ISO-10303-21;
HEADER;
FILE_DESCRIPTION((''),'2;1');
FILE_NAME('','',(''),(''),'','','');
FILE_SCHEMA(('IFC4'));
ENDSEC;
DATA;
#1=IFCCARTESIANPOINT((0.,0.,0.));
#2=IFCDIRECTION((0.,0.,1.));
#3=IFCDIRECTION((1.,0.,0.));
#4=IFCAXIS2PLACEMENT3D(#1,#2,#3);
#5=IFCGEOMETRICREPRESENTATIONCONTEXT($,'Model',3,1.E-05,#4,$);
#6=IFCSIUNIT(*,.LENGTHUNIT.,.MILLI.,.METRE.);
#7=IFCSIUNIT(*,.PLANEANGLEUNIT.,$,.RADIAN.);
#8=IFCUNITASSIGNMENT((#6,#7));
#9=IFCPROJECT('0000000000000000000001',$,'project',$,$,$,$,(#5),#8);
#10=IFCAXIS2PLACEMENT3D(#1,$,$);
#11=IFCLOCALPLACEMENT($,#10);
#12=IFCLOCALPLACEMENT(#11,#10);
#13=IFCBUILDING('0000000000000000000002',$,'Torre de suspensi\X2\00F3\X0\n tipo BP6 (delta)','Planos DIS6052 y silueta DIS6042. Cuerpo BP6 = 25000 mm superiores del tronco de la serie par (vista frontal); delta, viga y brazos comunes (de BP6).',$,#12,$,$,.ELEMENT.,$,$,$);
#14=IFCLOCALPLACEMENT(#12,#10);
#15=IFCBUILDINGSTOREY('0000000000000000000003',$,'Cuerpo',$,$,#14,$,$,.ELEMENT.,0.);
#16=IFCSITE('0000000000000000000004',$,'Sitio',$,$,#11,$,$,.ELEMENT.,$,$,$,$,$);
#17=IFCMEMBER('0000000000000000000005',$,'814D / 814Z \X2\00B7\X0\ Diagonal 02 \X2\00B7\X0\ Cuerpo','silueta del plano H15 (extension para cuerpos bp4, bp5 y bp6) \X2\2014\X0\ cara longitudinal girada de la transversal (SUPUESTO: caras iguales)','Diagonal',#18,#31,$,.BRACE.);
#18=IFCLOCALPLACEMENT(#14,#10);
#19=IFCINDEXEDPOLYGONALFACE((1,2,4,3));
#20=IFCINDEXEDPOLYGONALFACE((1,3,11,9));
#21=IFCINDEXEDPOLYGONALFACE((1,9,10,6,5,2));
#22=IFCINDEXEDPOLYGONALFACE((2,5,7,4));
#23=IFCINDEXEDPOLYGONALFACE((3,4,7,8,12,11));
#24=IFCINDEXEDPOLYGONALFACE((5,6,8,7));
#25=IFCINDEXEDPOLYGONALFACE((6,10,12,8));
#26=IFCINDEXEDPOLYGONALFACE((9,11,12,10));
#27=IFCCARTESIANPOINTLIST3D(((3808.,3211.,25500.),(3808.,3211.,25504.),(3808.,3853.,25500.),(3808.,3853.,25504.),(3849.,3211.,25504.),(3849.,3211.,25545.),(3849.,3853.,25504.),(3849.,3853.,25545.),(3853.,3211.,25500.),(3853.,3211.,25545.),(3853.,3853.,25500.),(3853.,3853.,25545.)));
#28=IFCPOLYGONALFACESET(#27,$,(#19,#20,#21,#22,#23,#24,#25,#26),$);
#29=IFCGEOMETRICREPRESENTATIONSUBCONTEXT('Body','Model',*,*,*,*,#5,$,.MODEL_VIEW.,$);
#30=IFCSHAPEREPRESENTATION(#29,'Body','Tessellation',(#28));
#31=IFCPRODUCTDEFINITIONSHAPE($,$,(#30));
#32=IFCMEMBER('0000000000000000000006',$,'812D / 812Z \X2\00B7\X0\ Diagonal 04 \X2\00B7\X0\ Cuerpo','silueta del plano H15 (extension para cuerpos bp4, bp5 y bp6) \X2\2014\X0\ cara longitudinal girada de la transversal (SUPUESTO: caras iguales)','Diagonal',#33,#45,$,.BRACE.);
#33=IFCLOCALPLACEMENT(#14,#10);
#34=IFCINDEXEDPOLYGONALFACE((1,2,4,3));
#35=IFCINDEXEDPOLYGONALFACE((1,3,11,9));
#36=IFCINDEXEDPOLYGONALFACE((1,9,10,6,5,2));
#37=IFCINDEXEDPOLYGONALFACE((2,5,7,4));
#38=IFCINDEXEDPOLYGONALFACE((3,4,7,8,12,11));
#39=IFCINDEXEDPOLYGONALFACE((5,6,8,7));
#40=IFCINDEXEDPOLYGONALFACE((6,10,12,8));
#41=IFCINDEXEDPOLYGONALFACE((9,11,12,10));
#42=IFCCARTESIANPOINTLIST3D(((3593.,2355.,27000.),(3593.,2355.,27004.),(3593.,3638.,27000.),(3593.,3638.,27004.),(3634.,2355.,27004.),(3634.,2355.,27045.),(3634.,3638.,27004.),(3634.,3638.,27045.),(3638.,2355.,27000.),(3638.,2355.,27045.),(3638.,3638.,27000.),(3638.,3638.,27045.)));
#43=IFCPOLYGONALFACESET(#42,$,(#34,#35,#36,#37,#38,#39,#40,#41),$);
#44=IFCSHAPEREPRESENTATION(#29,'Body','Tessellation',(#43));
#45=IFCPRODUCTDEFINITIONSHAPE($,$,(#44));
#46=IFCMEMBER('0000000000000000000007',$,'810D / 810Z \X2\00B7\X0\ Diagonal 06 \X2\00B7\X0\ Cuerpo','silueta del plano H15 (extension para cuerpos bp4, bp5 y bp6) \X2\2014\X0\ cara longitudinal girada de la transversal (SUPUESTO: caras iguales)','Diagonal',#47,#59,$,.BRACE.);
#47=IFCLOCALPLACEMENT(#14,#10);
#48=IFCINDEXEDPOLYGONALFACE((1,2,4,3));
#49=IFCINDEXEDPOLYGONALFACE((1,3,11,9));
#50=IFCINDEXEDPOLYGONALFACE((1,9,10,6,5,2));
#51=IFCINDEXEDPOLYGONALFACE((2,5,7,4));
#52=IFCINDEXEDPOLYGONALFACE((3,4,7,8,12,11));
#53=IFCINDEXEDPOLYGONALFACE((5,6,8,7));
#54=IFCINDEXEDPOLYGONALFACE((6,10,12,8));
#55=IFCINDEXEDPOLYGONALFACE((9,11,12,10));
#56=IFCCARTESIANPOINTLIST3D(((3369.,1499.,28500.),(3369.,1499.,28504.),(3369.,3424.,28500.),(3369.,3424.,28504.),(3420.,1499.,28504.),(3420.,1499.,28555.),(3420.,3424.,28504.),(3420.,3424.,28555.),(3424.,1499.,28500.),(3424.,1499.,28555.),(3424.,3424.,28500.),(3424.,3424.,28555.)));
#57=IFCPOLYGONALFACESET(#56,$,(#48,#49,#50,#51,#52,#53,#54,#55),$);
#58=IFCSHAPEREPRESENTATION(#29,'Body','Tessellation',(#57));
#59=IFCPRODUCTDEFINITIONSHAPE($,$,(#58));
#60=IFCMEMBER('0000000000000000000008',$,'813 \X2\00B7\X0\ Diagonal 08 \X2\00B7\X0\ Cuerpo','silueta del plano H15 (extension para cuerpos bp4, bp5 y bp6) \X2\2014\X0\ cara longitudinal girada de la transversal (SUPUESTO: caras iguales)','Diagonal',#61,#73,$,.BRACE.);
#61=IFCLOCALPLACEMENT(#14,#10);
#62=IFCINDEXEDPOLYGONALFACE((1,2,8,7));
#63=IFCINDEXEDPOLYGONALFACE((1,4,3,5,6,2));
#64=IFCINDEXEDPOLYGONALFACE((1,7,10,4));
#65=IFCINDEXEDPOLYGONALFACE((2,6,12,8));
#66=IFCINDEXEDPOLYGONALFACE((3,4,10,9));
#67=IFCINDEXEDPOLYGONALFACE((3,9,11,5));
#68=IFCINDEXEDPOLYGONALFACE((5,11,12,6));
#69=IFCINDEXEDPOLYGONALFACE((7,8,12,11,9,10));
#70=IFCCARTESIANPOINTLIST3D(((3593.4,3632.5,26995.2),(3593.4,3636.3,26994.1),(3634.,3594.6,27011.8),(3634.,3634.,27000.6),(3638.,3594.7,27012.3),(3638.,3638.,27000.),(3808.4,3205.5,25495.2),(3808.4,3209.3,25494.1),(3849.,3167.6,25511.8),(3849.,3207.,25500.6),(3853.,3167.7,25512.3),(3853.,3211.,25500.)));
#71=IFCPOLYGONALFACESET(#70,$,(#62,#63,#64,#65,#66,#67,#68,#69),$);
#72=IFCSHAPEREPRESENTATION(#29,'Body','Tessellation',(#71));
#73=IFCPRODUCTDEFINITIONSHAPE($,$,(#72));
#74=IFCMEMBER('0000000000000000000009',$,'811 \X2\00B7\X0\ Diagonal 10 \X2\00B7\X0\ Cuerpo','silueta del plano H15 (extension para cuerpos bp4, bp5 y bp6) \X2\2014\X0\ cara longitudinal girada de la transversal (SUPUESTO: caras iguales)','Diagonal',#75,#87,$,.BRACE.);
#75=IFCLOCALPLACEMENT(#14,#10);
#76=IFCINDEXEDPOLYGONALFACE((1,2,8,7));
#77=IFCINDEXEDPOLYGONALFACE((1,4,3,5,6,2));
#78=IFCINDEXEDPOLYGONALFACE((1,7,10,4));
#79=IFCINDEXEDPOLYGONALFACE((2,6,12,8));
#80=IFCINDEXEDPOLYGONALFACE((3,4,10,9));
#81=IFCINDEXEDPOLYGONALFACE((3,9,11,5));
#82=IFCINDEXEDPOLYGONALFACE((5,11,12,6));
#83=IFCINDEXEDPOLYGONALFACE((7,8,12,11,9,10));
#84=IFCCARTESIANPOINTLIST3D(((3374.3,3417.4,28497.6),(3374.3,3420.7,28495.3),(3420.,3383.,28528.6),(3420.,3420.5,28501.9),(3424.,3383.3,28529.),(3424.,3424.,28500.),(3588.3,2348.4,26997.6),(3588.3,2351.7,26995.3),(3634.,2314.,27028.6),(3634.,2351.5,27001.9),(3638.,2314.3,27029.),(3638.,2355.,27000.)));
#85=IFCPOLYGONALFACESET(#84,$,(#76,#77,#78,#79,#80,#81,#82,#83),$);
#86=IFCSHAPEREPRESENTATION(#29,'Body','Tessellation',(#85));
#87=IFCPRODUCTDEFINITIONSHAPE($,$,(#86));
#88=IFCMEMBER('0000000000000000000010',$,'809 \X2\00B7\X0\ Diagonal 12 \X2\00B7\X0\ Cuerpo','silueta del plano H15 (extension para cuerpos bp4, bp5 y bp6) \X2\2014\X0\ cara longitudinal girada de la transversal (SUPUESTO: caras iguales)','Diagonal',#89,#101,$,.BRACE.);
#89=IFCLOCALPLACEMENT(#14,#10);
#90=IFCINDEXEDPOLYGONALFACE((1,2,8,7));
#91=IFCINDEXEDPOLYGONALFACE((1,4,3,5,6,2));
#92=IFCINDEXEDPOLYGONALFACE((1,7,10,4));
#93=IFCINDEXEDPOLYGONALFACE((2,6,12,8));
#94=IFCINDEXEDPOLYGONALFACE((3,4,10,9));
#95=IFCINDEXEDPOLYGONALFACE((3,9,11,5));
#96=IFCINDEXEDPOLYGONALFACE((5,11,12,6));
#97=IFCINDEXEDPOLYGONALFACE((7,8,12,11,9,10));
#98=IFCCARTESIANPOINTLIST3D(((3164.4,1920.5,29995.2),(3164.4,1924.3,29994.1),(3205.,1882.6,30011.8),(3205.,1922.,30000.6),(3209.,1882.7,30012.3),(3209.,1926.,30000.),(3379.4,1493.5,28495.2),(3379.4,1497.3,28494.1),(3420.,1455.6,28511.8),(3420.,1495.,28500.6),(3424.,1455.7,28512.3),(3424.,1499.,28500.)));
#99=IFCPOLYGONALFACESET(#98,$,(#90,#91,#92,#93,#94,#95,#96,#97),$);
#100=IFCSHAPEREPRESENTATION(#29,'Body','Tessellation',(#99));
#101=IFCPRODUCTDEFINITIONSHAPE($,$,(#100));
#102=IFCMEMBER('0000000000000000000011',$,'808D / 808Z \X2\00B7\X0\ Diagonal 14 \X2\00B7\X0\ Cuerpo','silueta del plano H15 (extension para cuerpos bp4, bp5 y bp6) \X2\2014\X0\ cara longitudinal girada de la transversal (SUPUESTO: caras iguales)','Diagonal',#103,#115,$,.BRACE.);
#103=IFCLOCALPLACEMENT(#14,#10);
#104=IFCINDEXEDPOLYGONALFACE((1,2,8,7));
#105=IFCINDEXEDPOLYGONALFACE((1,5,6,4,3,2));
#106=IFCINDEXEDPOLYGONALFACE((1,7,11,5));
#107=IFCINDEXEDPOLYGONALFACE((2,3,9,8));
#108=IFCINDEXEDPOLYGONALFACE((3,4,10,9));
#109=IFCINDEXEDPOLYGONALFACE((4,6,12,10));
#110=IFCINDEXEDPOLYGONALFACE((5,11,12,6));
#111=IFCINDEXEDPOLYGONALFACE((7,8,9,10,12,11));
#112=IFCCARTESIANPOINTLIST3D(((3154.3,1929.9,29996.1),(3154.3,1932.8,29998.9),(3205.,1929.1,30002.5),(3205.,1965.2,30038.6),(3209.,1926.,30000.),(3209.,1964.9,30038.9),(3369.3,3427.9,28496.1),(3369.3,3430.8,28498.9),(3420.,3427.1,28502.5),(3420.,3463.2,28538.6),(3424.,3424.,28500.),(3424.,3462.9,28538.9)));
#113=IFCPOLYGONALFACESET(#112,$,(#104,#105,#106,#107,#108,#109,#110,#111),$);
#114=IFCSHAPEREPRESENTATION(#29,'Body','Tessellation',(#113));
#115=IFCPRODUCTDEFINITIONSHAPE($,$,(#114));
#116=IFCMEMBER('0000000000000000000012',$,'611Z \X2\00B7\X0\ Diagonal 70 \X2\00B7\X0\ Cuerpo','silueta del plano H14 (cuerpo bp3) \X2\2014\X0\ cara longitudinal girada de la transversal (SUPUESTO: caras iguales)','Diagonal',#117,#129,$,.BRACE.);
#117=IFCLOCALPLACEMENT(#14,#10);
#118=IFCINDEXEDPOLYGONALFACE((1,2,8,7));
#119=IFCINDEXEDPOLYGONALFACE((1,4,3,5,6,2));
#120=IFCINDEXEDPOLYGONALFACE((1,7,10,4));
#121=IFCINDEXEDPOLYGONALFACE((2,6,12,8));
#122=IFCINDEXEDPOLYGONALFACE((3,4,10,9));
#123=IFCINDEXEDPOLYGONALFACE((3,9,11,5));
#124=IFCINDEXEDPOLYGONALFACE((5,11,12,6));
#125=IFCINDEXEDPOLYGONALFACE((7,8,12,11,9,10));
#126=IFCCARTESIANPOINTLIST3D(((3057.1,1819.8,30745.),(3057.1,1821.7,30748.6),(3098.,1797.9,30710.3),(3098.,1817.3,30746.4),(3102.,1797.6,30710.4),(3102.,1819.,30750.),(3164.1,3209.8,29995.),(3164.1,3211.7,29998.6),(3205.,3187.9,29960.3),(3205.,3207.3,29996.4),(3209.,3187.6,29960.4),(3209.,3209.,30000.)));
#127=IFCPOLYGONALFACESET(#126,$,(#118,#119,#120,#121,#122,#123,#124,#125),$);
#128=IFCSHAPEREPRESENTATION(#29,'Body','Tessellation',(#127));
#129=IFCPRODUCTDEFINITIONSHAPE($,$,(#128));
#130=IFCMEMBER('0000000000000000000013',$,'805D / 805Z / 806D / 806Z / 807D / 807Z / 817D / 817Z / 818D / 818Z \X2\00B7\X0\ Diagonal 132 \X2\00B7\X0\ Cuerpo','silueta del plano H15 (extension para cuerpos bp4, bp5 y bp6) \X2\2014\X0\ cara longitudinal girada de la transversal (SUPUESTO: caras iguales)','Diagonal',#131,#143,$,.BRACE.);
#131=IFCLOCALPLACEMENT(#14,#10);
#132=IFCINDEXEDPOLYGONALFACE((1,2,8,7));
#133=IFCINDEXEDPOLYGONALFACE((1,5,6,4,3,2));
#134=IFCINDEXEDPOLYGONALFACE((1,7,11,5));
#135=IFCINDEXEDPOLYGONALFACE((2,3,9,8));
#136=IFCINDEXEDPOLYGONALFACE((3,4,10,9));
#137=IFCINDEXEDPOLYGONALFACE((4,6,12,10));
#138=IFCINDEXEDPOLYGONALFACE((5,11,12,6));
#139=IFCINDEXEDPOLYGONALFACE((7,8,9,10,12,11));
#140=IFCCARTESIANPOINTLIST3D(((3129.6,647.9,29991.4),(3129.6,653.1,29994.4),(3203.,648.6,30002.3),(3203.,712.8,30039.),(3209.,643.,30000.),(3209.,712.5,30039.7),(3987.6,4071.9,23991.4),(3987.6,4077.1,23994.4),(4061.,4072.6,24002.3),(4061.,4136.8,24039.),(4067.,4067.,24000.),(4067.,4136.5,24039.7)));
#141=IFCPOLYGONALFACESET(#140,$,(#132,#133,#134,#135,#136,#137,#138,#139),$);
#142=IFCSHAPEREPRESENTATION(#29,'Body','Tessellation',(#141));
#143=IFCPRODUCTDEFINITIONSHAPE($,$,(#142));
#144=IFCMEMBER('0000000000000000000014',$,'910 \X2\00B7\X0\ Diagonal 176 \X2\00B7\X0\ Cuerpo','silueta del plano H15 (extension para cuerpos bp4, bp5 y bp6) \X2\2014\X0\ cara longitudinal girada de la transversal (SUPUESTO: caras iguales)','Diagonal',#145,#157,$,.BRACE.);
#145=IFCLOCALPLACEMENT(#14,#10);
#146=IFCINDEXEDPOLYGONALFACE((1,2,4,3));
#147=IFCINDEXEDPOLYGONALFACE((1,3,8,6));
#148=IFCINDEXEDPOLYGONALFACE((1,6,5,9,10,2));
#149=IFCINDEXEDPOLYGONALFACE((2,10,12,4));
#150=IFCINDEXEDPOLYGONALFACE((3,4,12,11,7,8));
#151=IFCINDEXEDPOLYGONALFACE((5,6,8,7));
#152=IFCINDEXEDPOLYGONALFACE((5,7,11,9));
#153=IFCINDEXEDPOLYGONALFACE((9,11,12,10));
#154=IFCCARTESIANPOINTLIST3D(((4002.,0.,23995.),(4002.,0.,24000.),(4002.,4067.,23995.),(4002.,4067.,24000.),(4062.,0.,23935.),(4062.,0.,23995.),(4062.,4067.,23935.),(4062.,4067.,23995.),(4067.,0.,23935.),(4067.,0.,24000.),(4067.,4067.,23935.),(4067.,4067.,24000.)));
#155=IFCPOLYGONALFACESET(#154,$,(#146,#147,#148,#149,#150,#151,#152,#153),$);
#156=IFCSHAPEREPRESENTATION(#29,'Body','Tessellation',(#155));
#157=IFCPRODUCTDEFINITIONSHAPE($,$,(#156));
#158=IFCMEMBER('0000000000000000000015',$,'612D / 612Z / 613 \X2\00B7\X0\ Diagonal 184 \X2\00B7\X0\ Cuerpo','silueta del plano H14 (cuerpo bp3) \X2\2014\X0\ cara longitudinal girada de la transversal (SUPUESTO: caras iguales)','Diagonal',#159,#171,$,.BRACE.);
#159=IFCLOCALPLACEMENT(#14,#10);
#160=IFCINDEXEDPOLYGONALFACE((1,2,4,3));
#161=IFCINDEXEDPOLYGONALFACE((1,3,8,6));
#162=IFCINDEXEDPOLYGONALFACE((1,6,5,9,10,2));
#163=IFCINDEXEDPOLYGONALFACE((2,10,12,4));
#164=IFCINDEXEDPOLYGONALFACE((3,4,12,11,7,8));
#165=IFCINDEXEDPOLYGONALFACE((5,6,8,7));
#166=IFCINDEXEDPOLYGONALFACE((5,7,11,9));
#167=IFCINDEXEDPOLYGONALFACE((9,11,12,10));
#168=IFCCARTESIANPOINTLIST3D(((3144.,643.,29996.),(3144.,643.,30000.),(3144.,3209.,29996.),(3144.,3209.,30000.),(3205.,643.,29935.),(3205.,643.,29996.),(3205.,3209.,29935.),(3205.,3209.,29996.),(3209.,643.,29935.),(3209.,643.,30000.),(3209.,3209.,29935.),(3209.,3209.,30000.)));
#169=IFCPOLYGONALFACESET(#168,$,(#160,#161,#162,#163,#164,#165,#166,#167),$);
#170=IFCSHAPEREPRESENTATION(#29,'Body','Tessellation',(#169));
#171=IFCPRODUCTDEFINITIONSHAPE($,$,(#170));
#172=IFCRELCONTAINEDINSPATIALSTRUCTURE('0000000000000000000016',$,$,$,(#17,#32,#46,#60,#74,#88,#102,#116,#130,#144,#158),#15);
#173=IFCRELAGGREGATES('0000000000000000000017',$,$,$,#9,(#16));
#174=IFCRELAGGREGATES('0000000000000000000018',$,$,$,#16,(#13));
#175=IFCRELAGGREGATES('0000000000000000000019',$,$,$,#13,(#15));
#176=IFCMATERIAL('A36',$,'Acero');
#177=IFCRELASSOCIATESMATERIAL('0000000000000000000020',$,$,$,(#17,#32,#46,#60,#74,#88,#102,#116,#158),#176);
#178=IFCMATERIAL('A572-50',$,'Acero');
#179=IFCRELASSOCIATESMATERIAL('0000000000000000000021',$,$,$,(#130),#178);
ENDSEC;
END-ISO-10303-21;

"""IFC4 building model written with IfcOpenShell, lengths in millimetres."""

from ifc_helpers import new_model, si_unit, frame, frame_2d, origin, origin_with_axes, place, context, subcontext, project, spatial, l_section, extrude, material, element, save


model = new_model("IFC4")

# Units and contexts
model_context = context("Model", 3, precision=1e-05, world=origin_with_axes())
body_context = subcontext(model_context, "Body", "Model", "MODEL_VIEW")
ifc_project = project(units=[si_unit("LENGTHUNIT", "METRE", prefix="MILLI"), si_unit("PLANEANGLEUNIT", "RADIAN")], contexts=[model_context])

# Site, building, storey
site_placement = place(None, origin())
site = spatial("IfcSite", under=ifc_project, at=site_placement, Name="Sitio", CompositionType="ELEMENT")
building_placement = place(site_placement, origin())
building = spatial("IfcBuilding", under=site, at=building_placement, Name="Torre de suspensión tipo BP6 (delta)", Description="Planos DIS6052 y silueta DIS6042. Cuerpo BP6 = 25000 mm superiores del tronco de la serie par (vista frontal); delta, viga y brazos comunes (de BP6).", CompositionType="ELEMENT")
storey_placement = place(building_placement, origin())
storey = spatial("IfcBuildingStorey", under=building, at=storey_placement, Name="Cuerpo", CompositionType="ELEMENT", Elevation=0.0)

# Members
ifc_material_1 = material(Name="A36", Category="Acero")
ifc_material_2 = material(Name="A572-50", Category="Acero")
member_1_placement = place(storey_placement, frame((3853.0, 3211.0, 25500.0), z_axis=(0.0, 1.0, 0.0), x_axis=(-1.0, 0.0, 0.0)))
element("IfcMember", 1, at=member_1_placement, inside=storey, material=ifc_material_1, Name="814D / 814Z · Diagonal 02 · Cuerpo", Description="silueta del plano H15 (extension para cuerpos bp4, bp5 y bp6) — cara longitudinal girada de la transversal (SUPUESTO: caras iguales)", ObjectType="Diagonal", PredefinedType="BRACE", context=body_context, shape_type="SweptSolid", body=[
    extrude(l_section(Depth=45.0, Width=45.0, Thickness=4.0, at=frame_2d((22.5, 22.5))), None, (0.0, 0.0, 1.0), 642.0),
])
member_2_placement = place(storey_placement, frame((3638.0, 2355.0, 27000.0), z_axis=(0.0, 1.0, 0.0), x_axis=(-1.0, 0.0, 0.0)))
element("IfcMember", 2, at=member_2_placement, inside=storey, material=ifc_material_1, Name="812D / 812Z · Diagonal 04 · Cuerpo", Description="silueta del plano H15 (extension para cuerpos bp4, bp5 y bp6) — cara longitudinal girada de la transversal (SUPUESTO: caras iguales)", ObjectType="Diagonal", PredefinedType="BRACE", context=body_context, shape_type="SweptSolid", body=[
    extrude(l_section(Depth=45.0, Width=45.0, Thickness=4.0, at=frame_2d((22.5, 22.5))), None, (0.0, 0.0, 1.0), 1283.0),
])
member_3_placement = place(storey_placement, frame((3424.0, 1499.0, 28500.0), z_axis=(0.0, 1.0, 0.0), x_axis=(-1.0, 0.0, 0.0)))
element("IfcMember", 3, at=member_3_placement, inside=storey, material=ifc_material_1, Name="810D / 810Z · Diagonal 06 · Cuerpo", Description="silueta del plano H15 (extension para cuerpos bp4, bp5 y bp6) — cara longitudinal girada de la transversal (SUPUESTO: caras iguales)", ObjectType="Diagonal", PredefinedType="BRACE", context=body_context, shape_type="SweptSolid", body=[
    extrude(l_section(Depth=55.0, Width=55.0, Thickness=4.0, at=frame_2d((27.5, 27.5))), None, (0.0, 0.0, 1.0), 1925.0),
])
member_4_placement = place(storey_placement, frame((3853.0, 3211.0, 25500.0), z_axis=(-0.136565, 0.271224, 0.952779), x_axis=(-0.990631, -0.03739, -0.131347)))
element("IfcMember", 4, at=member_4_placement, inside=storey, material=ifc_material_1, Name="813 · Diagonal 08 · Cuerpo", Description="silueta del plano H15 (extension para cuerpos bp4, bp5 y bp6) — cara longitudinal girada de la transversal (SUPUESTO: caras iguales)", ObjectType="Diagonal", PredefinedType="BRACE", context=body_context, shape_type="SweptSolid", body=[
    extrude(l_section(Depth=45.0, Width=45.0, Thickness=4.0, at=frame_2d((22.5, 22.5))), None, (0.0, 0.0, 1.0), 1574.3),
])
member_5_placement = place(storey_placement, frame((3638.0, 2355.0, 27000.0), z_axis=(-0.115405, 0.576487, 0.808915), x_axis=(-0.993318, -0.066977, -0.093981)))
element("IfcMember", 5, at=member_5_placement, inside=storey, material=ifc_material_1, Name="811 · Diagonal 10 · Cuerpo", Description="silueta del plano H15 (extension para cuerpos bp4, bp5 y bp6) — cara longitudinal girada de la transversal (SUPUESTO: caras iguales)", ObjectType="Diagonal", PredefinedType="BRACE", context=body_context, shape_type="SweptSolid", body=[
    extrude(l_section(Depth=50.0, Width=50.0, Thickness=4.0, at=frame_2d((25.0, 25.0))), None, (0.0, 0.0, 1.0), 1854.3),
])
member_6_placement = place(storey_placement, frame((3424.0, 1499.0, 28500.0), z_axis=(-0.136565, 0.271224, 0.952779), x_axis=(-0.990631, -0.03739, -0.131347)))
element("IfcMember", 6, at=member_6_placement, inside=storey, material=ifc_material_1, Name="809 · Diagonal 12 · Cuerpo", Description="silueta del plano H15 (extension para cuerpos bp4, bp5 y bp6) — cara longitudinal girada de la transversal (SUPUESTO: caras iguales)", ObjectType="Diagonal", PredefinedType="BRACE", context=body_context, shape_type="SweptSolid", body=[
    extrude(l_section(Depth=45.0, Width=45.0, Thickness=4.0, at=frame_2d((22.5, 22.5))), None, (0.0, 0.0, 1.0), 1574.3),
])
member_7_placement = place(storey_placement, frame((3209.0, 1926.0, 30000.0), z_axis=(0.100902, 0.703029, -0.703967), x_axis=(-0.994896, 0.071301, -0.071396)))
element("IfcMember", 7, at=member_7_placement, inside=storey, material=ifc_material_1, Name="808D / 808Z · Diagonal 14 · Cuerpo", Description="silueta del plano H15 (extension para cuerpos bp4, bp5 y bp6) — cara longitudinal girada de la transversal (SUPUESTO: caras iguales)", ObjectType="Diagonal", PredefinedType="BRACE", context=body_context, shape_type="SweptSolid", body=[
    extrude(l_section(Depth=55.0, Width=55.0, Thickness=4.0, at=frame_2d((27.5, 27.5))), None, (0.0, 0.0, 1.0), 2130.8),
])
member_8_placement = place(storey_placement, frame((3209.0, 3209.0, 30000.0), z_axis=(-0.067591, -0.878052, 0.473769), x_axis=(-0.997713, 0.059484, -0.032096)))
element("IfcMember", 8, at=member_8_placement, inside=storey, material=ifc_material_1, Name="611Z · Diagonal 70 · Cuerpo", Description="silueta del plano H14 (cuerpo bp3) — cara longitudinal girada de la transversal (SUPUESTO: caras iguales)", ObjectType="Diagonal", PredefinedType="BRACE", context=body_context, shape_type="SweptSolid", body=[
    extrude(l_section(Depth=45.0, Width=45.0, Thickness=4.0, at=frame_2d((22.5, 22.5))), None, (0.0, 0.0, 1.0), 1583.1),
])
member_9_placement = place(storey_placement, frame((3209.0, 643.0, 30000.0), z_axis=(0.123253, 0.491861, -0.861906), x_axis=(-0.992375, 0.061089, -0.107048)))
element("IfcMember", 9, at=member_9_placement, inside=storey, material=ifc_material_2, Name="805D / 805Z / 806D / 806Z / 807D / 807Z / 817D / 817Z / 818D / 818Z · Diagonal 132 · Cuerpo", Description="silueta del plano H15 (extension para cuerpos bp4, bp5 y bp6) — cara longitudinal girada de la transversal (SUPUESTO: caras iguales)", ObjectType="Diagonal", PredefinedType="BRACE", context=body_context, shape_type="SweptSolid", body=[
    extrude(l_section(Depth=80.0, Width=80.0, Thickness=6.0, at=frame_2d((40.0, 40.0))), None, (0.0, 0.0, 1.0), 6961.3),
])
member_10_placement = place(storey_placement, frame((4067.0, 4067.0, 24000.0), z_axis=(0.0, -1.0, 0.0), x_axis=(-1.0, 0.0, 0.0)))
element("IfcMember", 10, at=member_10_placement, inside=storey, Name="910 · Diagonal 176 · Cuerpo", Description="silueta del plano H15 (extension para cuerpos bp4, bp5 y bp6) — cara longitudinal girada de la transversal (SUPUESTO: caras iguales)", ObjectType="Diagonal", PredefinedType="BRACE", context=body_context, shape_type="SweptSolid", body=[
    extrude(l_section(Depth=65.0, Width=65.0, Thickness=5.0, at=frame_2d((32.5, 32.5))), None, (0.0, 0.0, 1.0), 4067.0),
])
member_11_placement = place(storey_placement, frame((3209.0, 3209.0, 30000.0), z_axis=(0.0, -1.0, 0.0), x_axis=(-1.0, 0.0, 0.0)))
element("IfcMember", 11, at=member_11_placement, inside=storey, material=ifc_material_1, Name="612D / 612Z / 613 · Diagonal 184 · Cuerpo", Description="silueta del plano H14 (cuerpo bp3) — cara longitudinal girada de la transversal (SUPUESTO: caras iguales)", ObjectType="Diagonal", PredefinedType="BRACE", context=body_context, shape_type="SweptSolid", body=[
    extrude(l_section(Depth=65.0, Width=65.0, Thickness=4.0, at=frame_2d((32.5, 32.5))), None, (0.0, 0.0, 1.0), 2566.0),
])

save(model, "model.ifc")
